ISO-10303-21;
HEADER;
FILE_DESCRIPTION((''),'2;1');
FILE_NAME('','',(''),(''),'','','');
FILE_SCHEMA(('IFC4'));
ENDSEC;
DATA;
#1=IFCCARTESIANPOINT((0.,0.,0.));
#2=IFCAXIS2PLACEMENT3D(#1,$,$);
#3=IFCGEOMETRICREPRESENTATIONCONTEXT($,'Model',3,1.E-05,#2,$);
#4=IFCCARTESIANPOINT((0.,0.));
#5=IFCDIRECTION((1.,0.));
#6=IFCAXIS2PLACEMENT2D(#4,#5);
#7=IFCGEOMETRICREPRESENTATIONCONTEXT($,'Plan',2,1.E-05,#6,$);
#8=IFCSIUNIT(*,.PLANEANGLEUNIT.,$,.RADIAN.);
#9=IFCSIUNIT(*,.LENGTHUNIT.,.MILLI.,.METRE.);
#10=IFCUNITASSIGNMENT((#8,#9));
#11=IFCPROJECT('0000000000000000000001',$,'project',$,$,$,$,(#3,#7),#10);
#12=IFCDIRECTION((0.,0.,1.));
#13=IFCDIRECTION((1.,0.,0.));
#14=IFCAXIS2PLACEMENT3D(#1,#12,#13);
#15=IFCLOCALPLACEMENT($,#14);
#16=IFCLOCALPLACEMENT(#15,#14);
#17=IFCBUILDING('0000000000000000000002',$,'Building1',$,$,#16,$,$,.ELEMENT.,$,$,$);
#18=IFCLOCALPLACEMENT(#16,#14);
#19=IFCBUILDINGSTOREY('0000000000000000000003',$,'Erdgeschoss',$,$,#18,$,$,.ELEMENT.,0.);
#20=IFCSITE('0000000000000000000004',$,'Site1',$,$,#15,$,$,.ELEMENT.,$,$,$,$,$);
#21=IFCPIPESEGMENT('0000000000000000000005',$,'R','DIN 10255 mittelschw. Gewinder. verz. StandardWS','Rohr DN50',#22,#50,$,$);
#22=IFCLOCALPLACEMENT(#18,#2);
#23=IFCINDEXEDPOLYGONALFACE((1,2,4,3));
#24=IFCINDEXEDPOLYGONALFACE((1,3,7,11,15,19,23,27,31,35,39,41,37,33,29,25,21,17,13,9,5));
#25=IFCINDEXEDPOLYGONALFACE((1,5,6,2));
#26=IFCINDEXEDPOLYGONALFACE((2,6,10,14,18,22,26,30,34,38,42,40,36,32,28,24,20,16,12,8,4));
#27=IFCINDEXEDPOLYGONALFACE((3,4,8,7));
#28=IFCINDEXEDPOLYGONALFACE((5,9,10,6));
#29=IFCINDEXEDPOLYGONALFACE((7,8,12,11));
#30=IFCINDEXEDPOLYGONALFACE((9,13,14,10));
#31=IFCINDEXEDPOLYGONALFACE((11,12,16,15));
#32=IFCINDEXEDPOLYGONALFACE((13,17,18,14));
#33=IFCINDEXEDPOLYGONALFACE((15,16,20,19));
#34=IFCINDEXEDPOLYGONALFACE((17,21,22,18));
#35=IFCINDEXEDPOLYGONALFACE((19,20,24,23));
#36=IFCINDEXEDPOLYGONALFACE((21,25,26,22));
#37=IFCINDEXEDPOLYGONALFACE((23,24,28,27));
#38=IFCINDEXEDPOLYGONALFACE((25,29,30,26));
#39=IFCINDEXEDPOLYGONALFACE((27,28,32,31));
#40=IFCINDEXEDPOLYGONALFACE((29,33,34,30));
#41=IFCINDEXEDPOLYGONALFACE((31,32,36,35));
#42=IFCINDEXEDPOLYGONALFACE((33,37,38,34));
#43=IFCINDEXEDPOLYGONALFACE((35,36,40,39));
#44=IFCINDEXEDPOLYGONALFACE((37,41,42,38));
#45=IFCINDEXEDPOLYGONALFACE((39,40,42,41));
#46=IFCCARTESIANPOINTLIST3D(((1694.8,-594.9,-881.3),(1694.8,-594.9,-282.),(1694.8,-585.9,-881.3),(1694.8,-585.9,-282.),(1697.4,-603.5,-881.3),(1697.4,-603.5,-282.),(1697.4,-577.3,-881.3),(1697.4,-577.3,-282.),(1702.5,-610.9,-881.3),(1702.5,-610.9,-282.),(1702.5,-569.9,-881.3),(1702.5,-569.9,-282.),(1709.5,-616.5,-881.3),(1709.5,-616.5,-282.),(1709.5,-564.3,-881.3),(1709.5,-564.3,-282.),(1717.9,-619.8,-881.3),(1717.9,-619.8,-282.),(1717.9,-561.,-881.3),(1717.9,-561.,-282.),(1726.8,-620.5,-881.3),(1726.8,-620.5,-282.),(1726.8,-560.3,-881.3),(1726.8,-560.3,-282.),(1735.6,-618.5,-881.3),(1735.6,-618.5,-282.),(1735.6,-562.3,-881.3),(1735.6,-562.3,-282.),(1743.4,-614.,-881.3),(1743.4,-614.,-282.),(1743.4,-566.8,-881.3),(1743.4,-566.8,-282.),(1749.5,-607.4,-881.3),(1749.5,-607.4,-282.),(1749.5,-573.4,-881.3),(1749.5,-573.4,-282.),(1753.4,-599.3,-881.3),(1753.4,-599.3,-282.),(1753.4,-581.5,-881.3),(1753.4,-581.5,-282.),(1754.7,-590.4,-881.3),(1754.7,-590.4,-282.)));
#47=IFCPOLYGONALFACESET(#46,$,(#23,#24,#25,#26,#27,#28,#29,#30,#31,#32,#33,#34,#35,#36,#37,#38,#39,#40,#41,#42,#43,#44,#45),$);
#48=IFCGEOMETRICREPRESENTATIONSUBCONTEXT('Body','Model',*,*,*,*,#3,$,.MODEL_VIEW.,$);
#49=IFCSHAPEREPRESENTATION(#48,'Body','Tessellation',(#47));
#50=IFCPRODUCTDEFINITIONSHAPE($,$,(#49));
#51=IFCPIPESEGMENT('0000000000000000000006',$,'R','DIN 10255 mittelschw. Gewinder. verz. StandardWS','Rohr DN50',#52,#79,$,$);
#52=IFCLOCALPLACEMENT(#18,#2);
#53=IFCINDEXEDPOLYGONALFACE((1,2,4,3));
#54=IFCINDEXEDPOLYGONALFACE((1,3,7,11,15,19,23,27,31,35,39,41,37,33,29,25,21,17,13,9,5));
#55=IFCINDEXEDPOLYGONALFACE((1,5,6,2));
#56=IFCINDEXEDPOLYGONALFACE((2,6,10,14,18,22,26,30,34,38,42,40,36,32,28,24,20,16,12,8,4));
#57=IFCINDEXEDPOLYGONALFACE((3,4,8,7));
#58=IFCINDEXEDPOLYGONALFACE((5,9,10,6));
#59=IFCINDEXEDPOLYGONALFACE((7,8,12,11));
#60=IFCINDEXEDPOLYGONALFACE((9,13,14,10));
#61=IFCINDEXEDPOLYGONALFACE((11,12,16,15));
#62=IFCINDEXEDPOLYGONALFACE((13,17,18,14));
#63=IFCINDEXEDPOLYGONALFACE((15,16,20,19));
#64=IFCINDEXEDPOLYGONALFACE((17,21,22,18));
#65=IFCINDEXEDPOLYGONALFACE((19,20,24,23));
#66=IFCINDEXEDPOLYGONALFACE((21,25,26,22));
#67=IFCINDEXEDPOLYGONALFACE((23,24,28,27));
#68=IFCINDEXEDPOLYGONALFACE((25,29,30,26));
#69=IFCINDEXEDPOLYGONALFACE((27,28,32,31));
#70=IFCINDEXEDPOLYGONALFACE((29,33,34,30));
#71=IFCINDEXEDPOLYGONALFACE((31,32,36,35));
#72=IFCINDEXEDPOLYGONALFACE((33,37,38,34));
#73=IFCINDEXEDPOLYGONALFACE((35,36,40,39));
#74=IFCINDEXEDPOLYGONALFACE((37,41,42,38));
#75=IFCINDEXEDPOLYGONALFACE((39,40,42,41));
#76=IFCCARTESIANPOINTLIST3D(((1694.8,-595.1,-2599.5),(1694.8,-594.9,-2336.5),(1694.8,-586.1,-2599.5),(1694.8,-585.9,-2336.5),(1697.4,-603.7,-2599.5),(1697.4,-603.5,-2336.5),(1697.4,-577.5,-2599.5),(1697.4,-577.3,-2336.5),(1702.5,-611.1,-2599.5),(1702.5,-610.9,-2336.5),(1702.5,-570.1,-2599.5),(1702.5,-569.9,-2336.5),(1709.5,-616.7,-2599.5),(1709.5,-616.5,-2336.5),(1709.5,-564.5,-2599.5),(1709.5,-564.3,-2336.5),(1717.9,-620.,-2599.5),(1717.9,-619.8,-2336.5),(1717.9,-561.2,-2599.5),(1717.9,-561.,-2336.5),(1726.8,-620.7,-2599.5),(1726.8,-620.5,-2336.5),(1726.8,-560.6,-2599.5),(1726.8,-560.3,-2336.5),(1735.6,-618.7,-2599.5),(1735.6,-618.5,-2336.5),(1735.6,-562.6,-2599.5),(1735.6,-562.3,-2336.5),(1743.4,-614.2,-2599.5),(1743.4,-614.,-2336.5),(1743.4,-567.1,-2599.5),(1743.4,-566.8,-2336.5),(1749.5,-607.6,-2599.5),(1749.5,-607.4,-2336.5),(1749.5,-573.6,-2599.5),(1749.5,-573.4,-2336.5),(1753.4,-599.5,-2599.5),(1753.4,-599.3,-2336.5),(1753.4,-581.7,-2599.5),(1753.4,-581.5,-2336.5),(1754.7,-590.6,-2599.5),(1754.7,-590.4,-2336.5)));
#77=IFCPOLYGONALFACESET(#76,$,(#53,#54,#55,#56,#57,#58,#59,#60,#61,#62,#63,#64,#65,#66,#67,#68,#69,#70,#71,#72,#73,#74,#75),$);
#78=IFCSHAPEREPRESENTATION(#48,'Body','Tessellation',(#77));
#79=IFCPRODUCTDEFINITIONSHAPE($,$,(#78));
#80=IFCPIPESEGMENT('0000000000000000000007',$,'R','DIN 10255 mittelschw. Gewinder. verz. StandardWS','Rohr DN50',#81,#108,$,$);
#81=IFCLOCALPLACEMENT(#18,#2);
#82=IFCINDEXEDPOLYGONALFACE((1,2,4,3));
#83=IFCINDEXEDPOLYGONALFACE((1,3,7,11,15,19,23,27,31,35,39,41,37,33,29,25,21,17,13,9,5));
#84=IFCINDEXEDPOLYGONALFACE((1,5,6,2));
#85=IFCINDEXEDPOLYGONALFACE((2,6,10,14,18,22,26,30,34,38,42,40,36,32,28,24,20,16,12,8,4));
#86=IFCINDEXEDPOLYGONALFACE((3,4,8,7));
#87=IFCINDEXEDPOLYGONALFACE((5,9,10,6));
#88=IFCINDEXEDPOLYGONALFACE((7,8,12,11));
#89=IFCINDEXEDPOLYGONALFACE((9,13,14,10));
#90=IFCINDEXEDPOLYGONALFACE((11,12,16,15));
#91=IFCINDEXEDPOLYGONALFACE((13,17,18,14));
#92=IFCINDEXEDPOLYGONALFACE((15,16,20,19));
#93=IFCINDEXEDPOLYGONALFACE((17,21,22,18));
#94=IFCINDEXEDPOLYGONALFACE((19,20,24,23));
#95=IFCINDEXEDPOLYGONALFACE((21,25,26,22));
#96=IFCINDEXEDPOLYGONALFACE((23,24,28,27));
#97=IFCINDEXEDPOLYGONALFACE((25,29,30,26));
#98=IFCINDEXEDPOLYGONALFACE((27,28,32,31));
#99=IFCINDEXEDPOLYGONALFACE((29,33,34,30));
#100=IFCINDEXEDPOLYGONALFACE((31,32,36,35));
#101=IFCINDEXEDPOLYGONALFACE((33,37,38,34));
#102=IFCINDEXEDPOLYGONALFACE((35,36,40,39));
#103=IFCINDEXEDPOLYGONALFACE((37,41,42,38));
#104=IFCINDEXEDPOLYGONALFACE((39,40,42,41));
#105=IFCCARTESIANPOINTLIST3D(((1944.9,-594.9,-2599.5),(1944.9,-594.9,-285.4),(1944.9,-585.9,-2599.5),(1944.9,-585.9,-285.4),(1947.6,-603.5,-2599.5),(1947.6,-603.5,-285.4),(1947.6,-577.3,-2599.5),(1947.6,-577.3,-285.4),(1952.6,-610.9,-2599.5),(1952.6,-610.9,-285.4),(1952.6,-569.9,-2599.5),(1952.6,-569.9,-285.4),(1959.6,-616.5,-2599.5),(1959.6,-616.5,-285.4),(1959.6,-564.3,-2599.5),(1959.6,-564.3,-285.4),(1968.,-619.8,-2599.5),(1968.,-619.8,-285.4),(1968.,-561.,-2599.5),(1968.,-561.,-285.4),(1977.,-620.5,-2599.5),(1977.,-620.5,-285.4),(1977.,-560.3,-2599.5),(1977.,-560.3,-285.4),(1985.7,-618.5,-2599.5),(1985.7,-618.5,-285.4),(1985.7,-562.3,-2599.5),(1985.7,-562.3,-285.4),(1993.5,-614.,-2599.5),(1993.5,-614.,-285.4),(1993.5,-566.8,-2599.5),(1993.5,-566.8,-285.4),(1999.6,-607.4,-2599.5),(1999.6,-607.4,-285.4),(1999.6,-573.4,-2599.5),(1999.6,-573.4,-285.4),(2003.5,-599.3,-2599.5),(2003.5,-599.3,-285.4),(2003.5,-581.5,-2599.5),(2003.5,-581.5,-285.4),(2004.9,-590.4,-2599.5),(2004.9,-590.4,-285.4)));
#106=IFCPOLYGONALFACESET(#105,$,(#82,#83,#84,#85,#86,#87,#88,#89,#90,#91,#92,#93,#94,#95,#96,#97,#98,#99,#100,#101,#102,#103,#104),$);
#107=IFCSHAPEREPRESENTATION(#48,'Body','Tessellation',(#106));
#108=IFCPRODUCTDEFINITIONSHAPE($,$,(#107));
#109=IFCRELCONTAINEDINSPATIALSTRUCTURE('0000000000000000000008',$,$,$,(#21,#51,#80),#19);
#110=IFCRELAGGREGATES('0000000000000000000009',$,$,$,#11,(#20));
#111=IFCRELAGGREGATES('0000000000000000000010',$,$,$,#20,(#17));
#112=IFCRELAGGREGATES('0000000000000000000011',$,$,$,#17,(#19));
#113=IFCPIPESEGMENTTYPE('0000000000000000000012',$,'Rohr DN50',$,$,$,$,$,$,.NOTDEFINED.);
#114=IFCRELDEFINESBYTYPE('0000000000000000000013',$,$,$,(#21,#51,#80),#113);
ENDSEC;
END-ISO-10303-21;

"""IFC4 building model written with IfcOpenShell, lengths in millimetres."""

from ifc_helpers import new_model, si_unit, frame, origin, origin_with_axes, origin_2d_with_axis, place, context, subcontext, project, spatial, circle, extrude, type_object, element, save


model = new_model("IFC4")

# Units and contexts
model_context = context("Model", 3, precision=1e-05, world=origin())
plan_context = context("Plan", 2, precision=1e-05, world=origin_2d_with_axis())
body_context = subcontext(model_context, "Body", "Model", "MODEL_VIEW")
ifc_project = project(units=[si_unit("PLANEANGLEUNIT", "RADIAN"), si_unit("LENGTHUNIT", "METRE", prefix="MILLI")], contexts=[model_context, plan_context])

# Site, building, storey
site_placement = place(None, origin_with_axes())
site = spatial("IfcSite", under=ifc_project, at=site_placement, Name="Site1", CompositionType="ELEMENT")
building_placement = place(site_placement, origin_with_axes())
building = spatial("IfcBuilding", under=site, at=building_placement, Name="Building1", CompositionType="ELEMENT")
storey_placement = place(building_placement, origin_with_axes())
storey = spatial("IfcBuildingStorey", under=building, at=storey_placement, Name="Erdgeschoss", CompositionType="ELEMENT", Elevation=0.0)

# Pipe segments
pipe_segment_type_1 = type_object("IfcPipeSegmentType", Name="Rohr DN50", PredefinedType="NOTDEFINED")
pipe_segment_1_placement = place(storey_placement, frame((1724.6, -590.6, -581.6), z_axis=(0.0, 0.0, 1.0), x_axis=(1.0, 0.0, 0.0)))
element("IfcPipeSegment", 1, at=pipe_segment_1_placement, inside=storey, type_object=pipe_segment_type_1, Name="R", Description="DIN 10255 mittelschw. Gewinder. verz. StandardWS", ObjectType="Rohr DN50", context=body_context, shape_type="SolidModel", body=[
    extrude(circle(Radius=30.1, at=origin_2d_with_axis()), frame((0.0, 0.1, -299.6), z_axis=(0.0, 0.0, 1.0), x_axis=(1.0, 0.0, 0.0)), (0.0, 0.0, 1.0), 599.3),
])
pipe_segment_2_placement = place(storey_placement, frame((1724.6, -590.7, -2468.0), z_axis=(0.0, 0.0, 1.0), x_axis=(1.0, 0.0, 0.0)))
element("IfcPipeSegment", 2, at=pipe_segment_2_placement, inside=storey, type_object=pipe_segment_type_1, Name="R", Description="DIN 10255 mittelschw. Gewinder. verz. StandardWS", ObjectType="Rohr DN50", context=body_context, shape_type="SolidModel", body=[
    extrude(circle(Radius=30.1, at=origin_2d_with_axis()), frame((0.0, 0.0, -131.5), z_axis=(0.0, 0.000808, 1.0), x_axis=(1.0, 0.0, 0.0)), (0.0, 0.0, 1.0), 263.0),
])
pipe_segment_3_placement = place(storey_placement, frame((1974.7, -590.6, -1442.4), z_axis=(0.0, 0.0, 1.0), x_axis=(1.0, 0.0, 0.0)))
element("IfcPipeSegment", 3, at=pipe_segment_3_placement, inside=storey, type_object=pipe_segment_type_1, Name="R", Description="DIN 10255 mittelschw. Gewinder. verz. StandardWS", ObjectType="Rohr DN50", context=body_context, shape_type="SolidModel", body=[
    extrude(circle(Radius=30.1, at=origin_2d_with_axis()), frame((0.0, 0.1, -1157.1), z_axis=(0.0, 0.0, 1.0), x_axis=(1.0, 0.0, 0.0)), (0.0, 0.0, 1.0), 2314.1),
])

save(model, "model.ifc")
